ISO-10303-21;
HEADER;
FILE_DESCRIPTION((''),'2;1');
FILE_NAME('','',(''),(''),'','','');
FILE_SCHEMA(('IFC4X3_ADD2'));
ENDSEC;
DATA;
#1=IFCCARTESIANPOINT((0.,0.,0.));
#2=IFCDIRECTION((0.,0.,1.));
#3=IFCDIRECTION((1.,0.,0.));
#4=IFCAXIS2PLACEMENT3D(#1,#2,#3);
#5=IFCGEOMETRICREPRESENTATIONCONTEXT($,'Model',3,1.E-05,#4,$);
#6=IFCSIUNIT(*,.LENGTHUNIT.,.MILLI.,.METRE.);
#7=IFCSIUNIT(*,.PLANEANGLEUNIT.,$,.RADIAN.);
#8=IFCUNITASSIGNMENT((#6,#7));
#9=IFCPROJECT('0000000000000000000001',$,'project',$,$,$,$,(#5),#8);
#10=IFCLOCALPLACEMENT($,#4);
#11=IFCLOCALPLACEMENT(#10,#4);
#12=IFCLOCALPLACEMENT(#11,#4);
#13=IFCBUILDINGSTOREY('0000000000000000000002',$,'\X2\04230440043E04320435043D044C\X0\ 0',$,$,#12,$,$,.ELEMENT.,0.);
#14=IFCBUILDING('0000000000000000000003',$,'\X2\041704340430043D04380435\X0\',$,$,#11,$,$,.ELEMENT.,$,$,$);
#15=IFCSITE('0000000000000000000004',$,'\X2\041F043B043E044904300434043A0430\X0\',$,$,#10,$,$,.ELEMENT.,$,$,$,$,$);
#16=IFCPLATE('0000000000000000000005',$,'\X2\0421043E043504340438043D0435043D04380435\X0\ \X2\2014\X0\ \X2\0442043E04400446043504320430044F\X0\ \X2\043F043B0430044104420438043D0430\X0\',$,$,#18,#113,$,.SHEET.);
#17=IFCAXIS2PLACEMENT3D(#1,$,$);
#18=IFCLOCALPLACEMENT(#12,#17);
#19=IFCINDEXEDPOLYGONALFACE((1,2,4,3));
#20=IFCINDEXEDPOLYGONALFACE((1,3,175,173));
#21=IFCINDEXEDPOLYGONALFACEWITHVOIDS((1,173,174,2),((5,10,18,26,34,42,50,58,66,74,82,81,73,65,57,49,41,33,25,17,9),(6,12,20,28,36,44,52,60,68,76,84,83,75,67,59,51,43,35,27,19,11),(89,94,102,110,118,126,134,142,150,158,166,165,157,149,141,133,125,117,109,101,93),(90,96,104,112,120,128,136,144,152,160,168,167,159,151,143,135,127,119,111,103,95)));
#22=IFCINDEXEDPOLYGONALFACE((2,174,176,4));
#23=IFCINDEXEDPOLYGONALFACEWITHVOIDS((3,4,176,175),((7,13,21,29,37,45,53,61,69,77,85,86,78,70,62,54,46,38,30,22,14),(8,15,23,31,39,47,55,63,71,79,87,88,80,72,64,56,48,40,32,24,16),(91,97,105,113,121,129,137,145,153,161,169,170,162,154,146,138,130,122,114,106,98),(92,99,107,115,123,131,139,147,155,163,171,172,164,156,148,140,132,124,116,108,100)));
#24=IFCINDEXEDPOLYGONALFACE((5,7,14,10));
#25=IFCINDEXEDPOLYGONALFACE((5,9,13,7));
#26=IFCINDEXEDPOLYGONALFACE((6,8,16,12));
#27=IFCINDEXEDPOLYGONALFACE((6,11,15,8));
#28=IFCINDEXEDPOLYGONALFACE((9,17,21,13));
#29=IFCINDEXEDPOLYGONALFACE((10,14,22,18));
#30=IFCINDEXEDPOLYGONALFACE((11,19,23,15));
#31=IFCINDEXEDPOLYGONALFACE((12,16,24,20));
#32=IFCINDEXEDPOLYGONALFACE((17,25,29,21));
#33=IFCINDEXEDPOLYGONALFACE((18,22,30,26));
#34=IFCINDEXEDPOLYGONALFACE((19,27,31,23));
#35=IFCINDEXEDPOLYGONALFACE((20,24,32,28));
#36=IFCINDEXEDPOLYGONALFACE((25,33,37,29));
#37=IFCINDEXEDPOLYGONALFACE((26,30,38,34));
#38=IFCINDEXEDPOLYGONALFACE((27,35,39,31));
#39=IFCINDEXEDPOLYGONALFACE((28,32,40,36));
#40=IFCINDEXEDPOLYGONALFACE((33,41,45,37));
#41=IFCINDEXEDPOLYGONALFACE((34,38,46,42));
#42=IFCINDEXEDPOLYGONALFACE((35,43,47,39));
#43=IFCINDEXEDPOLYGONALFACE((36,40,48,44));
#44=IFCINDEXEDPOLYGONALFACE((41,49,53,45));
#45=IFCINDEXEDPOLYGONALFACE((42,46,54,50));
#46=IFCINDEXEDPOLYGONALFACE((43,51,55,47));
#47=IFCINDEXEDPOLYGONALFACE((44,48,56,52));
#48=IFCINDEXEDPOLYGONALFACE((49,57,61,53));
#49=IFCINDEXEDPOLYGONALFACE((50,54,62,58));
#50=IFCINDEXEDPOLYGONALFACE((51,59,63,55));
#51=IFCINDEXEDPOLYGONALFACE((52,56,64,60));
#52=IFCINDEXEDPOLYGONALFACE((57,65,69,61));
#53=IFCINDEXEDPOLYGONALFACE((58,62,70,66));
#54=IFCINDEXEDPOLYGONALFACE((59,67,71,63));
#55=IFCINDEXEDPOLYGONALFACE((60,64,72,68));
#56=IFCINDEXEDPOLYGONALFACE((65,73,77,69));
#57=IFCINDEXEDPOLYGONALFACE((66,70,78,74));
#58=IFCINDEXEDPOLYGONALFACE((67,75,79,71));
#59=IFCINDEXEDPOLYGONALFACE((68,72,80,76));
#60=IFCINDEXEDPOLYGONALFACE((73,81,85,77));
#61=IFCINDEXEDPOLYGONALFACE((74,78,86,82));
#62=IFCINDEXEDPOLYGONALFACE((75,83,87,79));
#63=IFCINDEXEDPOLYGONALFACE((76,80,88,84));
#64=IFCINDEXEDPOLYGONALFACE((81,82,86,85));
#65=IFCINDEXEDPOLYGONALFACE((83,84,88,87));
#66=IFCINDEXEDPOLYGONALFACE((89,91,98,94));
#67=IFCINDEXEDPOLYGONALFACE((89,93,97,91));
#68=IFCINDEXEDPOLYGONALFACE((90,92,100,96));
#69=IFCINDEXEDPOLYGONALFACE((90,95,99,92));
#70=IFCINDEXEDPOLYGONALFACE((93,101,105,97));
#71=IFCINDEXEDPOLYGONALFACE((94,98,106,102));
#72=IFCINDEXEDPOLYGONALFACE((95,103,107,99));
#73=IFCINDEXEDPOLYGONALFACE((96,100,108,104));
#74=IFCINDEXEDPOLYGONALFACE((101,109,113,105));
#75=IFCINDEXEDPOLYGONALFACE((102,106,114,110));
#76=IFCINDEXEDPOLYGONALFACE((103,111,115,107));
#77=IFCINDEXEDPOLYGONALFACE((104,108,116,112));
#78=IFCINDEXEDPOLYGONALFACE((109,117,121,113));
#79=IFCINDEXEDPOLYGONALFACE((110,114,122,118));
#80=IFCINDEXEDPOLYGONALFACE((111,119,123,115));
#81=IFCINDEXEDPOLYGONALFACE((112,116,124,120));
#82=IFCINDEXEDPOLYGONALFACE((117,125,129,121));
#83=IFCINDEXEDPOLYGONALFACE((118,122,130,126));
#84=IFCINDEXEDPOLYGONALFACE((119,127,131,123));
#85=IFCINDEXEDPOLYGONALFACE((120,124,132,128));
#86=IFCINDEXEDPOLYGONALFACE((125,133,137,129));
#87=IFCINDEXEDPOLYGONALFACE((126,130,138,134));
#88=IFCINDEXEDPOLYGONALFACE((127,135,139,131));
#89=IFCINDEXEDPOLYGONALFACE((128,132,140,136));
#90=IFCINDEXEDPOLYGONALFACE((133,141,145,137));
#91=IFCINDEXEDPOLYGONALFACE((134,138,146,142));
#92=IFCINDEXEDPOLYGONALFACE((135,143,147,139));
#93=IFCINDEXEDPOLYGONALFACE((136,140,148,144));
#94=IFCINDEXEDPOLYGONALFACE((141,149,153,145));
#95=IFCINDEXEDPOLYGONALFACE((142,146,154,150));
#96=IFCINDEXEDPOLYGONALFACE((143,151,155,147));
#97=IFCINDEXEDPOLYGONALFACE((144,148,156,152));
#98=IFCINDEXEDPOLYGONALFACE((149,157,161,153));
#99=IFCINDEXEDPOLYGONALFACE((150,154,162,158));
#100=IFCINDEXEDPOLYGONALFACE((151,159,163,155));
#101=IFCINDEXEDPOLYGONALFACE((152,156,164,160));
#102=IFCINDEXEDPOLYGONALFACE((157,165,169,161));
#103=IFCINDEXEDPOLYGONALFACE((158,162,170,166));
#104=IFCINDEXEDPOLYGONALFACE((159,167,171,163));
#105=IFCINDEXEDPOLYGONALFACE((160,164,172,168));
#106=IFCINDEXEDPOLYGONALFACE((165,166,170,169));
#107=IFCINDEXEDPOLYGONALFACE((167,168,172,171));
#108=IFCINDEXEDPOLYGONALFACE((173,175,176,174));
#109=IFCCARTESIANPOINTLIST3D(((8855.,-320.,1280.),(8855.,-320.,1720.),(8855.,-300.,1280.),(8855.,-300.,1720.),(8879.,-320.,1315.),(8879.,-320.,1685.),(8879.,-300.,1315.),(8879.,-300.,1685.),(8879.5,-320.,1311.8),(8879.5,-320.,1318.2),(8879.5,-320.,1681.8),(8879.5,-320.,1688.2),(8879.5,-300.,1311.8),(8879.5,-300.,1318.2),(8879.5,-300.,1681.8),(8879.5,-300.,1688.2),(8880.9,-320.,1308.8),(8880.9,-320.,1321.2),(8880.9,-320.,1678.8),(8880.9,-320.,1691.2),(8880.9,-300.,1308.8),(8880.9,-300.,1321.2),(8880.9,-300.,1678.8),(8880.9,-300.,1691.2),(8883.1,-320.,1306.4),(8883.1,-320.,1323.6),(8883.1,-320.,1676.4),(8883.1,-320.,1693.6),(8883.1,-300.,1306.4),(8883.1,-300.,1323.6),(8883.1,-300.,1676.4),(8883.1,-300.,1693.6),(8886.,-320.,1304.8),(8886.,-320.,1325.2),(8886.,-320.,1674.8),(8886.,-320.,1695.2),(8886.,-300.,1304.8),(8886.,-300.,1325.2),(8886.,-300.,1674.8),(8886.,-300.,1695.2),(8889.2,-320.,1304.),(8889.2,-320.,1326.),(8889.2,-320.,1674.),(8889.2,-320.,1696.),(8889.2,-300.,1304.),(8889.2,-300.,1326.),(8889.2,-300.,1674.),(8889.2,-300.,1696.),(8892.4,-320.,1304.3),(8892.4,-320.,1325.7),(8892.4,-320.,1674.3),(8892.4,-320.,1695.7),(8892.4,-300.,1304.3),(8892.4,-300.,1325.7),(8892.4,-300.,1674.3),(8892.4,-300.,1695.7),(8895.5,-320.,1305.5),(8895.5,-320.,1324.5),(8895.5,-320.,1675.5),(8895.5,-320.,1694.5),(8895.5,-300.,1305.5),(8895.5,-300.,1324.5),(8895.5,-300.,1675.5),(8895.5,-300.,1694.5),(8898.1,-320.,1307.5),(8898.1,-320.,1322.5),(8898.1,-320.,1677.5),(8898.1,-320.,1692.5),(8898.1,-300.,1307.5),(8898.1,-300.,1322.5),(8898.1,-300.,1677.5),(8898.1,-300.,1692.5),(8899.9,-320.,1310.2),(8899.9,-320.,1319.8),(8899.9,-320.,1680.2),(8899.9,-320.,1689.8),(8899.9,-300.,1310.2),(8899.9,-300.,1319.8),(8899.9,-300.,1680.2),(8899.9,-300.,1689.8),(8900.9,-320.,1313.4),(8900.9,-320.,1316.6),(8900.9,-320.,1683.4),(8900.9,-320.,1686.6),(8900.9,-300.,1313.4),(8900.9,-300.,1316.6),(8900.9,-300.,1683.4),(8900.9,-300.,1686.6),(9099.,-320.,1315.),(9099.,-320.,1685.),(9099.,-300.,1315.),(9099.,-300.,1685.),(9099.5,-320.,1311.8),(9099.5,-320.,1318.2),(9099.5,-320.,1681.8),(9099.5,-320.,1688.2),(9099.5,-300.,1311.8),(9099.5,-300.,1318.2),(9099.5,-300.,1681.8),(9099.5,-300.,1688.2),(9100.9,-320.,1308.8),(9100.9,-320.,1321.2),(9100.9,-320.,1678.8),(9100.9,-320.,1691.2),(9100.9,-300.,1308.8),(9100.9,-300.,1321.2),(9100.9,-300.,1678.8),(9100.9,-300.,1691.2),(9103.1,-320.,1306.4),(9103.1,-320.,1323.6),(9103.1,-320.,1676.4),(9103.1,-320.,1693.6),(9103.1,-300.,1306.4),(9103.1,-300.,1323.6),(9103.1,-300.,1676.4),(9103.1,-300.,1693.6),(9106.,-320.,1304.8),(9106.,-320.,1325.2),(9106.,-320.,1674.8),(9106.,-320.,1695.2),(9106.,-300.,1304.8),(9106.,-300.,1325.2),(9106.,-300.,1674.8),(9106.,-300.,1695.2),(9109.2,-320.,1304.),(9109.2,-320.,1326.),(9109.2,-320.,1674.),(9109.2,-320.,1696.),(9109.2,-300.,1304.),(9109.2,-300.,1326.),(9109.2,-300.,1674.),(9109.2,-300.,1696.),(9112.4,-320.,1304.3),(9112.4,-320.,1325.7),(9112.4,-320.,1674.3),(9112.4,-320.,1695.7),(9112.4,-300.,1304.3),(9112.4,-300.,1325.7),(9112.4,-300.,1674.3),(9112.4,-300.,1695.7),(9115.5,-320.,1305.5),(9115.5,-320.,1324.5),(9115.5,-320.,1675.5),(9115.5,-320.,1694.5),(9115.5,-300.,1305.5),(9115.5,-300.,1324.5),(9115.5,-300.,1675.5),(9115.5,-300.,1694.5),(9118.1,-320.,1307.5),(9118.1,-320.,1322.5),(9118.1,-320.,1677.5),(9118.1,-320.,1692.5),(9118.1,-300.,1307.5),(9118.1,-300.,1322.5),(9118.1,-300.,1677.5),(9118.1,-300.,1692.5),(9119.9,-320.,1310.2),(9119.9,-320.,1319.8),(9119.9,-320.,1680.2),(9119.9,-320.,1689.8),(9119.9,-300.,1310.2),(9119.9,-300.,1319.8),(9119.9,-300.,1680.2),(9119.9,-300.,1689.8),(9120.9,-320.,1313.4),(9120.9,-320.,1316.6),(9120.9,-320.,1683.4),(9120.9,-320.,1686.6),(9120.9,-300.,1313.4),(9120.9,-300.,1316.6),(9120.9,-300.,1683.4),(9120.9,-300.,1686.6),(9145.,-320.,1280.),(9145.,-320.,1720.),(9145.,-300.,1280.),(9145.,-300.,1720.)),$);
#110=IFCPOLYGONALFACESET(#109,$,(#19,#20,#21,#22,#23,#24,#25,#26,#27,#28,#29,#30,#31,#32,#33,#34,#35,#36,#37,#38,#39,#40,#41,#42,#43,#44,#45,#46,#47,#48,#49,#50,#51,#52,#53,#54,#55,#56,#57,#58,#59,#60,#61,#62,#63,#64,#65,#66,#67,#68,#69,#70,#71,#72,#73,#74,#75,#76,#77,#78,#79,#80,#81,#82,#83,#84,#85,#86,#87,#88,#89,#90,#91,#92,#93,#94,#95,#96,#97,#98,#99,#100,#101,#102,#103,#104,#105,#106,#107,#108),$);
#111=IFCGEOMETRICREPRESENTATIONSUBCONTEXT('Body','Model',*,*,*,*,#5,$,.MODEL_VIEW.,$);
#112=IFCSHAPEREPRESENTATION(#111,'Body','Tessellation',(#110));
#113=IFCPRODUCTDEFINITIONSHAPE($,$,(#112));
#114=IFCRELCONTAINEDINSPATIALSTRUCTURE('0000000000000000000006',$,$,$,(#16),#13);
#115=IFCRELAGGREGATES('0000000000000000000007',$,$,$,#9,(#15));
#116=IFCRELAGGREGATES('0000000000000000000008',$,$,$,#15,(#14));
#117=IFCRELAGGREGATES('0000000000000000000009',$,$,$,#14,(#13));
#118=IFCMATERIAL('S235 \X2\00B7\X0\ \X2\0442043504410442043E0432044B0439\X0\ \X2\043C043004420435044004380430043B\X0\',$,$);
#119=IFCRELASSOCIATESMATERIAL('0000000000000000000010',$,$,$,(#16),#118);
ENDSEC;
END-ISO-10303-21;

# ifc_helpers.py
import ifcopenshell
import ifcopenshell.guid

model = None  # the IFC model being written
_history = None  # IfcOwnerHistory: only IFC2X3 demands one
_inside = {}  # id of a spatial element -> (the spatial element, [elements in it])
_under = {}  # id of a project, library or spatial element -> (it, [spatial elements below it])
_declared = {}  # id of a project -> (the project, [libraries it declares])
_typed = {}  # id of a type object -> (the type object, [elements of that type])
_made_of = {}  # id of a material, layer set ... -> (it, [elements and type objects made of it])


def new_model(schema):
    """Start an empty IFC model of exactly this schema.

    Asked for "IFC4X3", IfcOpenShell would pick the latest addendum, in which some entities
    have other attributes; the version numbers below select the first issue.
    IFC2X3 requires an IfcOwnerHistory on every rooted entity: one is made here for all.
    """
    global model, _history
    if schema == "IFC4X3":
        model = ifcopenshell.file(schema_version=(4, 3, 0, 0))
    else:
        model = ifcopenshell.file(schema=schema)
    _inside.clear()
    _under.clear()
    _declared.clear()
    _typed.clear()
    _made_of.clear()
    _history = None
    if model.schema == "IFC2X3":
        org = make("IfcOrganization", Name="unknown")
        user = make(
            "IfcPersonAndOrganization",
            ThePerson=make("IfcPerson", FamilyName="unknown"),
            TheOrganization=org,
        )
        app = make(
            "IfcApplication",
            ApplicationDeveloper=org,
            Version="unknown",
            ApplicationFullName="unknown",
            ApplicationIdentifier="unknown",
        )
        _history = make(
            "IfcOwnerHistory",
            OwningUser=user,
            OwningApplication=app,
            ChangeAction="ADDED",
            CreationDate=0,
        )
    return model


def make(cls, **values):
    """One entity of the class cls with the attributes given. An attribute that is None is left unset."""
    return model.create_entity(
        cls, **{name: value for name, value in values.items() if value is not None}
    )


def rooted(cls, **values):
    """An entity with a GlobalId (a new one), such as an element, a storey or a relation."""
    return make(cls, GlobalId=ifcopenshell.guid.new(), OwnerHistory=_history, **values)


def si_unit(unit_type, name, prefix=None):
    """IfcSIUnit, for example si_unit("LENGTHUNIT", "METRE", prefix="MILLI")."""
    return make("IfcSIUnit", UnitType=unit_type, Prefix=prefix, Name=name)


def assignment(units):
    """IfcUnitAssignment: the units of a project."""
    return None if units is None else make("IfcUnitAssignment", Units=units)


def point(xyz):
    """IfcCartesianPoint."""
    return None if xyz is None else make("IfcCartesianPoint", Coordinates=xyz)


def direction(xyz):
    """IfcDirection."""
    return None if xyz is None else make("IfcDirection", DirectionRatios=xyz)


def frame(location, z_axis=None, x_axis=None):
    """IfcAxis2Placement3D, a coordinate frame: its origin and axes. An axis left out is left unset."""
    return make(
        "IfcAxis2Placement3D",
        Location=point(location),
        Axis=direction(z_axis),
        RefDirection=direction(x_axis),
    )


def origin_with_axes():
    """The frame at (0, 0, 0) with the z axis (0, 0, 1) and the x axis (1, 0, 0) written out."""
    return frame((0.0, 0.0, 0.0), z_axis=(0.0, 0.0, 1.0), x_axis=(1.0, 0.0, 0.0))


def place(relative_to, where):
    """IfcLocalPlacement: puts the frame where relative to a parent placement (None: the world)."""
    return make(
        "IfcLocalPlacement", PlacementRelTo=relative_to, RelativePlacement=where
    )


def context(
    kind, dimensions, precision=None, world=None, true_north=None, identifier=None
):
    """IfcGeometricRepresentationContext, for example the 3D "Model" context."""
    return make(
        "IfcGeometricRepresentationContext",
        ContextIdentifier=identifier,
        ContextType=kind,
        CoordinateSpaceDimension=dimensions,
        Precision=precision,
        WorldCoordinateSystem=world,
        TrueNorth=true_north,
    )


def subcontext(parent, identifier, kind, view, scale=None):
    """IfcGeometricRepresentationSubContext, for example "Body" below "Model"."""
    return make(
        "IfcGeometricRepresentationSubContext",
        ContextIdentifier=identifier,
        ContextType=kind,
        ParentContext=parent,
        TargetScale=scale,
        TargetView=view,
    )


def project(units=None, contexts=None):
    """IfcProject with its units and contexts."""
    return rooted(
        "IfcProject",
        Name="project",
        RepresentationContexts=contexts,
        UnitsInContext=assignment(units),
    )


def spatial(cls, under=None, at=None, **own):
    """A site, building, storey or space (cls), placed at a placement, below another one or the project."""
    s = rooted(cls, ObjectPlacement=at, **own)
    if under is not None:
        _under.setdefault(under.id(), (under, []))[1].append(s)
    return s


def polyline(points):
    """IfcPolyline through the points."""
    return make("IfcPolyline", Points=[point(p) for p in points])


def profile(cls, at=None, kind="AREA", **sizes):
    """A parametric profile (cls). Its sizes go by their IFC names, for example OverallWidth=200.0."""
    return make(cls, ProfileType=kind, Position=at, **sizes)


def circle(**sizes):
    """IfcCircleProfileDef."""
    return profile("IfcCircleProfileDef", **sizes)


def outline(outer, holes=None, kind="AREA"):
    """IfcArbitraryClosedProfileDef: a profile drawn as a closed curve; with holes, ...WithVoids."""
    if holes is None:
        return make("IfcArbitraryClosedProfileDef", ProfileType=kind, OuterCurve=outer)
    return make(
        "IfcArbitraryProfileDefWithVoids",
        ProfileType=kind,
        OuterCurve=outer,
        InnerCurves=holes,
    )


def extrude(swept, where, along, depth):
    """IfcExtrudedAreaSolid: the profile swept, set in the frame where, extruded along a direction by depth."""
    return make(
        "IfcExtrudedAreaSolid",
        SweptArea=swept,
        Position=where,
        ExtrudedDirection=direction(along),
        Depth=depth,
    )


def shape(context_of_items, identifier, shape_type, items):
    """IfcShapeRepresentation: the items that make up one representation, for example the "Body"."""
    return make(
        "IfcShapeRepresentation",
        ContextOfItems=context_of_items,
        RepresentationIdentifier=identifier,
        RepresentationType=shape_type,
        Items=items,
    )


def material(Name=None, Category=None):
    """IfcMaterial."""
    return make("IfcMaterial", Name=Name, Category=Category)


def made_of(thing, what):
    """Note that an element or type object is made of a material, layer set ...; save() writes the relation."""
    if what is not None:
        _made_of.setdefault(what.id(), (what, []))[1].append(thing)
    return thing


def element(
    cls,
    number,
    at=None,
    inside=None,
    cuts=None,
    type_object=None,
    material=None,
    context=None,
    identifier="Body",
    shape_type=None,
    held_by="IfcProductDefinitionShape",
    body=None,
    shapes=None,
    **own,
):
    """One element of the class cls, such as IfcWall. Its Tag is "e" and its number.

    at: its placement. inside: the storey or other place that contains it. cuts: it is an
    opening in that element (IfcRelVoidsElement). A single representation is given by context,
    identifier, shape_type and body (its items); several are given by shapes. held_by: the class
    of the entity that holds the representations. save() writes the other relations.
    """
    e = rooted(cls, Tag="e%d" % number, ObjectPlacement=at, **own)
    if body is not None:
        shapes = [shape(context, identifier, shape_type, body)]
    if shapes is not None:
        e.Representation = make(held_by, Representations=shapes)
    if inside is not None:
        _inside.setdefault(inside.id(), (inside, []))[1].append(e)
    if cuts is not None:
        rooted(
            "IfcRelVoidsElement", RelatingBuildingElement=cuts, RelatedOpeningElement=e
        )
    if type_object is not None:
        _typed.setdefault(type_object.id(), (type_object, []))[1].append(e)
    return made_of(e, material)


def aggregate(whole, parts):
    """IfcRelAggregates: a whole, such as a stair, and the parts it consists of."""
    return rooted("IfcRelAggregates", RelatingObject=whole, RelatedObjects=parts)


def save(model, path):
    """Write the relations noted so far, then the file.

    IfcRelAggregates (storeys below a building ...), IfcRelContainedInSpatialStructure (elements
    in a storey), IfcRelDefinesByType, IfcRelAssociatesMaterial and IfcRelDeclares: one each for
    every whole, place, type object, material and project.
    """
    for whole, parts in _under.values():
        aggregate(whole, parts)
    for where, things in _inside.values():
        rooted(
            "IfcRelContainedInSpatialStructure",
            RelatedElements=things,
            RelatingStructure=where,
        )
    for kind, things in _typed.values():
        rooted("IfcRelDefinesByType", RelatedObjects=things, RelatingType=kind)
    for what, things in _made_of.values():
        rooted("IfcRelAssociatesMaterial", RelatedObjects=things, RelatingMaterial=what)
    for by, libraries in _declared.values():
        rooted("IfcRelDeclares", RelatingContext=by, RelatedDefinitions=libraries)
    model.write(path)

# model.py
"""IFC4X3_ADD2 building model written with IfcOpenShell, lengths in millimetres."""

from ifc_helpers import new_model, si_unit, frame, origin_with_axes, place, context, subcontext, project, spatial, polyline, circle, outline, extrude, material, element, save


model = new_model("IFC4X3_ADD2")

# Units and contexts
model_context = context("Model", 3, precision=1e-05, world=origin_with_axes())
body_context = subcontext(model_context, "Body", "Model", "MODEL_VIEW")
ifc_project = project(units=[si_unit("LENGTHUNIT", "METRE", prefix="MILLI"), si_unit("PLANEANGLEUNIT", "RADIAN")], contexts=[model_context])

# Site, building, storey
site_placement = place(None, origin_with_axes())
site = spatial("IfcSite", under=ifc_project, at=site_placement, Name="Площадка", CompositionType="ELEMENT")
building_placement = place(site_placement, origin_with_axes())
building = spatial("IfcBuilding", under=site, at=building_placement, Name="Здание", CompositionType="ELEMENT")
storey_placement = place(building_placement, origin_with_axes())
storey = spatial("IfcBuildingStorey", under=building, at=storey_placement, Name="Уровень 0", CompositionType="ELEMENT", Elevation=0.0)

# Shared definitions
ifc_material = material(Name="S235 · тестовый материал")

# Plate, openings
plate_placement = place(storey_placement, frame((9145.0, -320.0, 1280.0), z_axis=(0.0, 1.0, 0.0), x_axis=(-1.0, 0.0, 0.0)))
plate = element("IfcPlate", 1, at=plate_placement, inside=storey, material=ifc_material, Name="Соединение — торцевая пластина", PredefinedType="SHEET", context=body_context, shape_type="SweptSolid", body=[
    extrude(outline(polyline([(0.0, 0.0), (290.0, 0.0), (290.0, 440.0), (0.0, 440.0), (0.0, 0.0)])), origin_with_axes(), (0.0, 0.0, 1.0), 20.0),
])
opening_1_placement = place(plate_placement, frame((35.0, 35.0, -1.0), z_axis=(0.0, 0.0, 1.0), x_axis=(1.0, 0.0, 0.0)))
element("IfcOpeningElement", 2, at=opening_1_placement, cuts=plate, PredefinedType="OPENING", context=body_context, shape_type="SweptSolid", body=[
    extrude(circle(Radius=11.0), origin_with_axes(), (0.0, 0.0, 1.0), 42.0),
])
opening_2_placement = place(plate_placement, frame((35.0, 405.0, -1.0), z_axis=(0.0, 0.0, 1.0), x_axis=(1.0, 0.0, 0.0)))
element("IfcOpeningElement", 3, at=opening_2_placement, cuts=plate, PredefinedType="OPENING", context=body_context, shape_type="SweptSolid", body=[
    extrude(circle(Radius=11.0), origin_with_axes(), (0.0, 0.0, 1.0), 42.0),
])
opening_3_placement = place(plate_placement, frame((255.0, 35.0, -1.0), z_axis=(0.0, 0.0, 1.0), x_axis=(1.0, 0.0, 0.0)))
element("IfcOpeningElement", 4, at=opening_3_placement, cuts=plate, PredefinedType="OPENING", context=body_context, shape_type="SweptSolid", body=[
    extrude(circle(Radius=11.0), origin_with_axes(), (0.0, 0.0, 1.0), 42.0),
])
opening_4_placement = place(plate_placement, frame((255.0, 405.0, -1.0), z_axis=(0.0, 0.0, 1.0), x_axis=(1.0, 0.0, 0.0)))
element("IfcOpeningElement", 5, at=opening_4_placement, cuts=plate, PredefinedType="OPENING", context=body_context, shape_type="SweptSolid", body=[
    extrude(circle(Radius=11.0), origin_with_axes(), (0.0, 0.0, 1.0), 42.0),
])

save(model, "model.ifc")
